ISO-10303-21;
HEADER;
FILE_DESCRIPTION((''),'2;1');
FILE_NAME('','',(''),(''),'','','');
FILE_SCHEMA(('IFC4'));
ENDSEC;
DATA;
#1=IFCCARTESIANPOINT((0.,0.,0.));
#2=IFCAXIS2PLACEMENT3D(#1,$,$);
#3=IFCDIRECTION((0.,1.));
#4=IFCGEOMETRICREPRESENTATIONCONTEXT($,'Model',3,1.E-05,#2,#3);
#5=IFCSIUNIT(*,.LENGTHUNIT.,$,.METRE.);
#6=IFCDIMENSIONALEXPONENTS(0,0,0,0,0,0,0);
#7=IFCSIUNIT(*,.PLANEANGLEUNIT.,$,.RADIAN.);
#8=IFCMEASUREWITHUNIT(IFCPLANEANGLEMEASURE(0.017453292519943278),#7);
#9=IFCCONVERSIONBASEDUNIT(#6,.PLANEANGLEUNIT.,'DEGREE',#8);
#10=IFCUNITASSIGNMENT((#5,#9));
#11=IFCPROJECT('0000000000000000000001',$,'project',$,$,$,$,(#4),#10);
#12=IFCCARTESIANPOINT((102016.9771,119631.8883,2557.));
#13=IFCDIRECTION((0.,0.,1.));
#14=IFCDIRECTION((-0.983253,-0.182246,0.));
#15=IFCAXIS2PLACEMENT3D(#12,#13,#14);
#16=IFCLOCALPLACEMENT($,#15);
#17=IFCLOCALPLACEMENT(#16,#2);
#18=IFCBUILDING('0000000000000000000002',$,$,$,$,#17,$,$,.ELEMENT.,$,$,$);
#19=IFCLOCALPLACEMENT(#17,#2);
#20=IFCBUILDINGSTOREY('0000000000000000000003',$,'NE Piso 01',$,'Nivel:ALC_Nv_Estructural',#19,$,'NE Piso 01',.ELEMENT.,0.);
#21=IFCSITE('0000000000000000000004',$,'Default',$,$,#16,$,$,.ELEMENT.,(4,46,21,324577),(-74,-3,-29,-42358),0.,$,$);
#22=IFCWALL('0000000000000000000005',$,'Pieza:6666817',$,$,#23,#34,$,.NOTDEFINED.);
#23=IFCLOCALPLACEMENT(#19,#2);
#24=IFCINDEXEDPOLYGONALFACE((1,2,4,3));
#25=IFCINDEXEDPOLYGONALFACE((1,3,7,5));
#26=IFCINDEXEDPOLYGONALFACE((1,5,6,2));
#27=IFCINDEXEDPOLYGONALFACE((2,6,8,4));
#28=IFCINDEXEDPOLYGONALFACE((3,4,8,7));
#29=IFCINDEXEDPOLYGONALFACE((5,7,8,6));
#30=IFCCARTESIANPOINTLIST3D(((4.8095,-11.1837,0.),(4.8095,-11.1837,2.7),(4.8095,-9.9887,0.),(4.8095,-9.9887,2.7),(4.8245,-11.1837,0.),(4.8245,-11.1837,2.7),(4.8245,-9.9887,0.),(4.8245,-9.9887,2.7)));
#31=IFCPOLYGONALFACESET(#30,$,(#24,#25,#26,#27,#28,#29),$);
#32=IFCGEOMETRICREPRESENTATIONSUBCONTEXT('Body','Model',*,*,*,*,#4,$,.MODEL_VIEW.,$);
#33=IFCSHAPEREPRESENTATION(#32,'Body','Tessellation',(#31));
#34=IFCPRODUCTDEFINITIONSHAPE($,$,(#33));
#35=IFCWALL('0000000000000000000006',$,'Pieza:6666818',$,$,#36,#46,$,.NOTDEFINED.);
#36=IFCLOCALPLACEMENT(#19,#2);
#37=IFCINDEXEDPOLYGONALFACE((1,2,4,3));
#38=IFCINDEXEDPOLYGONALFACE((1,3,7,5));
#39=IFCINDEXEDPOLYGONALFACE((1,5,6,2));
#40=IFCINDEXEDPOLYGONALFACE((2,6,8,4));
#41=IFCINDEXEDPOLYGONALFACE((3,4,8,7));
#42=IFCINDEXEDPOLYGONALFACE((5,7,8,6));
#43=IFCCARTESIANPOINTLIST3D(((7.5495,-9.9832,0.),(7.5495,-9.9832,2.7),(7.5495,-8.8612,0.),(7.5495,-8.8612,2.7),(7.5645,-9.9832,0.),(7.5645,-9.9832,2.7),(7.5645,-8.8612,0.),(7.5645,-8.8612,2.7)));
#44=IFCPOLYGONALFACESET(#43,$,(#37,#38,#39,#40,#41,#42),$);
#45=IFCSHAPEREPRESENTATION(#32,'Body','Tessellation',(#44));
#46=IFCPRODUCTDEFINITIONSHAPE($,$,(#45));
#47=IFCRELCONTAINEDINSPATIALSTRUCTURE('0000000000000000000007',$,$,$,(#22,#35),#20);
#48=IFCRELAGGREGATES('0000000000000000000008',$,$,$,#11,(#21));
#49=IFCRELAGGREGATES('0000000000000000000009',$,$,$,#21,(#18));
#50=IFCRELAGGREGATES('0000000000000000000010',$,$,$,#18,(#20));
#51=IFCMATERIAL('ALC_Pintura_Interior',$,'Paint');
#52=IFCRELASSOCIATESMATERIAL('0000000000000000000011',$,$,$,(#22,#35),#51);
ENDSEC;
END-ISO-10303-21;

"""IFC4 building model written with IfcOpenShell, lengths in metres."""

from ifc_helpers import new_model, entity, si_unit, converted_unit, direction, frame, frame_2d, origin, place, context, subcontext, project, spatial, rectangle, extrude, material, element, save


model = new_model("IFC4")

# Units and contexts
model_context = context("Model", 3, precision=1e-05, world=origin(), true_north=direction((0.0, 1.0)))
body_context = subcontext(model_context, "Body", "Model", "MODEL_VIEW")
ifc_project = project(units=[si_unit("LENGTHUNIT", "METRE"), converted_unit("PLANEANGLEUNIT", "DEGREE", entity("IfcPlaneAngleMeasure", 0.017453292519943278), si_unit("PLANEANGLEUNIT", "RADIAN"), dimensions=[0, 0, 0, 0, 0, 0, 0])], contexts=[model_context])

# Site, building, storey
site_placement = place(None, frame((102016.9771, 119631.8883, 2557.0), z_axis=(0.0, 0.0, 1.0), x_axis=(-0.983253, -0.182246, 0.0)))
site = spatial("IfcSite", under=ifc_project, at=site_placement, Name="Default", CompositionType="ELEMENT", RefLatitude=(4, 46, 21, 324577), RefLongitude=(-74, -3, -29, -42358), RefElevation=0.0)
building_placement = place(site_placement, origin())
building = spatial("IfcBuilding", under=site, at=building_placement, CompositionType="ELEMENT")
storey_placement = place(building_placement, origin())
storey = spatial("IfcBuildingStorey", under=building, at=storey_placement, Name="NE Piso 01", ObjectType="Nivel:ALC_Nv_Estructural", LongName="NE Piso 01", CompositionType="ELEMENT", Elevation=0.0)

# Walls
ifc_material_1 = material(Name="ALC_Pintura_Interior", Category="Paint")
wall_1_placement = place(storey_placement, origin())
element("IfcWall", 1, at=wall_1_placement, inside=storey, material=ifc_material_1, Name="Pieza:6666817", PredefinedType="NOTDEFINED", context=body_context, shape_type="SweptSolid", body=[
    extrude(rectangle(XDim=1.195, YDim=0.015, at=frame_2d((0.0, 0.0), x_axis=(1.0, 0.0))), frame((4.817, -10.5862, 0.0), z_axis=(0.0, 0.0, 1.0), x_axis=(0.0, -1.0, 0.0)), (0.0, 0.0, 1.0), 2.7),
])
wall_2_placement = place(storey_placement, origin())
element("IfcWall", 2, at=wall_2_placement, inside=storey, material=ifc_material_1, Name="Pieza:6666818", PredefinedType="NOTDEFINED", context=body_context, shape_type="SweptSolid", body=[
    extrude(rectangle(XDim=1.122, YDim=0.015, at=frame_2d((0.0, 0.0), x_axis=(1.0, 0.0))), frame((7.557, -9.4222, 0.0), z_axis=(0.0, 0.0, 1.0), x_axis=(0.0, -1.0, 0.0)), (0.0, 0.0, 1.0), 2.7),
])

save(model, "model.ifc")
